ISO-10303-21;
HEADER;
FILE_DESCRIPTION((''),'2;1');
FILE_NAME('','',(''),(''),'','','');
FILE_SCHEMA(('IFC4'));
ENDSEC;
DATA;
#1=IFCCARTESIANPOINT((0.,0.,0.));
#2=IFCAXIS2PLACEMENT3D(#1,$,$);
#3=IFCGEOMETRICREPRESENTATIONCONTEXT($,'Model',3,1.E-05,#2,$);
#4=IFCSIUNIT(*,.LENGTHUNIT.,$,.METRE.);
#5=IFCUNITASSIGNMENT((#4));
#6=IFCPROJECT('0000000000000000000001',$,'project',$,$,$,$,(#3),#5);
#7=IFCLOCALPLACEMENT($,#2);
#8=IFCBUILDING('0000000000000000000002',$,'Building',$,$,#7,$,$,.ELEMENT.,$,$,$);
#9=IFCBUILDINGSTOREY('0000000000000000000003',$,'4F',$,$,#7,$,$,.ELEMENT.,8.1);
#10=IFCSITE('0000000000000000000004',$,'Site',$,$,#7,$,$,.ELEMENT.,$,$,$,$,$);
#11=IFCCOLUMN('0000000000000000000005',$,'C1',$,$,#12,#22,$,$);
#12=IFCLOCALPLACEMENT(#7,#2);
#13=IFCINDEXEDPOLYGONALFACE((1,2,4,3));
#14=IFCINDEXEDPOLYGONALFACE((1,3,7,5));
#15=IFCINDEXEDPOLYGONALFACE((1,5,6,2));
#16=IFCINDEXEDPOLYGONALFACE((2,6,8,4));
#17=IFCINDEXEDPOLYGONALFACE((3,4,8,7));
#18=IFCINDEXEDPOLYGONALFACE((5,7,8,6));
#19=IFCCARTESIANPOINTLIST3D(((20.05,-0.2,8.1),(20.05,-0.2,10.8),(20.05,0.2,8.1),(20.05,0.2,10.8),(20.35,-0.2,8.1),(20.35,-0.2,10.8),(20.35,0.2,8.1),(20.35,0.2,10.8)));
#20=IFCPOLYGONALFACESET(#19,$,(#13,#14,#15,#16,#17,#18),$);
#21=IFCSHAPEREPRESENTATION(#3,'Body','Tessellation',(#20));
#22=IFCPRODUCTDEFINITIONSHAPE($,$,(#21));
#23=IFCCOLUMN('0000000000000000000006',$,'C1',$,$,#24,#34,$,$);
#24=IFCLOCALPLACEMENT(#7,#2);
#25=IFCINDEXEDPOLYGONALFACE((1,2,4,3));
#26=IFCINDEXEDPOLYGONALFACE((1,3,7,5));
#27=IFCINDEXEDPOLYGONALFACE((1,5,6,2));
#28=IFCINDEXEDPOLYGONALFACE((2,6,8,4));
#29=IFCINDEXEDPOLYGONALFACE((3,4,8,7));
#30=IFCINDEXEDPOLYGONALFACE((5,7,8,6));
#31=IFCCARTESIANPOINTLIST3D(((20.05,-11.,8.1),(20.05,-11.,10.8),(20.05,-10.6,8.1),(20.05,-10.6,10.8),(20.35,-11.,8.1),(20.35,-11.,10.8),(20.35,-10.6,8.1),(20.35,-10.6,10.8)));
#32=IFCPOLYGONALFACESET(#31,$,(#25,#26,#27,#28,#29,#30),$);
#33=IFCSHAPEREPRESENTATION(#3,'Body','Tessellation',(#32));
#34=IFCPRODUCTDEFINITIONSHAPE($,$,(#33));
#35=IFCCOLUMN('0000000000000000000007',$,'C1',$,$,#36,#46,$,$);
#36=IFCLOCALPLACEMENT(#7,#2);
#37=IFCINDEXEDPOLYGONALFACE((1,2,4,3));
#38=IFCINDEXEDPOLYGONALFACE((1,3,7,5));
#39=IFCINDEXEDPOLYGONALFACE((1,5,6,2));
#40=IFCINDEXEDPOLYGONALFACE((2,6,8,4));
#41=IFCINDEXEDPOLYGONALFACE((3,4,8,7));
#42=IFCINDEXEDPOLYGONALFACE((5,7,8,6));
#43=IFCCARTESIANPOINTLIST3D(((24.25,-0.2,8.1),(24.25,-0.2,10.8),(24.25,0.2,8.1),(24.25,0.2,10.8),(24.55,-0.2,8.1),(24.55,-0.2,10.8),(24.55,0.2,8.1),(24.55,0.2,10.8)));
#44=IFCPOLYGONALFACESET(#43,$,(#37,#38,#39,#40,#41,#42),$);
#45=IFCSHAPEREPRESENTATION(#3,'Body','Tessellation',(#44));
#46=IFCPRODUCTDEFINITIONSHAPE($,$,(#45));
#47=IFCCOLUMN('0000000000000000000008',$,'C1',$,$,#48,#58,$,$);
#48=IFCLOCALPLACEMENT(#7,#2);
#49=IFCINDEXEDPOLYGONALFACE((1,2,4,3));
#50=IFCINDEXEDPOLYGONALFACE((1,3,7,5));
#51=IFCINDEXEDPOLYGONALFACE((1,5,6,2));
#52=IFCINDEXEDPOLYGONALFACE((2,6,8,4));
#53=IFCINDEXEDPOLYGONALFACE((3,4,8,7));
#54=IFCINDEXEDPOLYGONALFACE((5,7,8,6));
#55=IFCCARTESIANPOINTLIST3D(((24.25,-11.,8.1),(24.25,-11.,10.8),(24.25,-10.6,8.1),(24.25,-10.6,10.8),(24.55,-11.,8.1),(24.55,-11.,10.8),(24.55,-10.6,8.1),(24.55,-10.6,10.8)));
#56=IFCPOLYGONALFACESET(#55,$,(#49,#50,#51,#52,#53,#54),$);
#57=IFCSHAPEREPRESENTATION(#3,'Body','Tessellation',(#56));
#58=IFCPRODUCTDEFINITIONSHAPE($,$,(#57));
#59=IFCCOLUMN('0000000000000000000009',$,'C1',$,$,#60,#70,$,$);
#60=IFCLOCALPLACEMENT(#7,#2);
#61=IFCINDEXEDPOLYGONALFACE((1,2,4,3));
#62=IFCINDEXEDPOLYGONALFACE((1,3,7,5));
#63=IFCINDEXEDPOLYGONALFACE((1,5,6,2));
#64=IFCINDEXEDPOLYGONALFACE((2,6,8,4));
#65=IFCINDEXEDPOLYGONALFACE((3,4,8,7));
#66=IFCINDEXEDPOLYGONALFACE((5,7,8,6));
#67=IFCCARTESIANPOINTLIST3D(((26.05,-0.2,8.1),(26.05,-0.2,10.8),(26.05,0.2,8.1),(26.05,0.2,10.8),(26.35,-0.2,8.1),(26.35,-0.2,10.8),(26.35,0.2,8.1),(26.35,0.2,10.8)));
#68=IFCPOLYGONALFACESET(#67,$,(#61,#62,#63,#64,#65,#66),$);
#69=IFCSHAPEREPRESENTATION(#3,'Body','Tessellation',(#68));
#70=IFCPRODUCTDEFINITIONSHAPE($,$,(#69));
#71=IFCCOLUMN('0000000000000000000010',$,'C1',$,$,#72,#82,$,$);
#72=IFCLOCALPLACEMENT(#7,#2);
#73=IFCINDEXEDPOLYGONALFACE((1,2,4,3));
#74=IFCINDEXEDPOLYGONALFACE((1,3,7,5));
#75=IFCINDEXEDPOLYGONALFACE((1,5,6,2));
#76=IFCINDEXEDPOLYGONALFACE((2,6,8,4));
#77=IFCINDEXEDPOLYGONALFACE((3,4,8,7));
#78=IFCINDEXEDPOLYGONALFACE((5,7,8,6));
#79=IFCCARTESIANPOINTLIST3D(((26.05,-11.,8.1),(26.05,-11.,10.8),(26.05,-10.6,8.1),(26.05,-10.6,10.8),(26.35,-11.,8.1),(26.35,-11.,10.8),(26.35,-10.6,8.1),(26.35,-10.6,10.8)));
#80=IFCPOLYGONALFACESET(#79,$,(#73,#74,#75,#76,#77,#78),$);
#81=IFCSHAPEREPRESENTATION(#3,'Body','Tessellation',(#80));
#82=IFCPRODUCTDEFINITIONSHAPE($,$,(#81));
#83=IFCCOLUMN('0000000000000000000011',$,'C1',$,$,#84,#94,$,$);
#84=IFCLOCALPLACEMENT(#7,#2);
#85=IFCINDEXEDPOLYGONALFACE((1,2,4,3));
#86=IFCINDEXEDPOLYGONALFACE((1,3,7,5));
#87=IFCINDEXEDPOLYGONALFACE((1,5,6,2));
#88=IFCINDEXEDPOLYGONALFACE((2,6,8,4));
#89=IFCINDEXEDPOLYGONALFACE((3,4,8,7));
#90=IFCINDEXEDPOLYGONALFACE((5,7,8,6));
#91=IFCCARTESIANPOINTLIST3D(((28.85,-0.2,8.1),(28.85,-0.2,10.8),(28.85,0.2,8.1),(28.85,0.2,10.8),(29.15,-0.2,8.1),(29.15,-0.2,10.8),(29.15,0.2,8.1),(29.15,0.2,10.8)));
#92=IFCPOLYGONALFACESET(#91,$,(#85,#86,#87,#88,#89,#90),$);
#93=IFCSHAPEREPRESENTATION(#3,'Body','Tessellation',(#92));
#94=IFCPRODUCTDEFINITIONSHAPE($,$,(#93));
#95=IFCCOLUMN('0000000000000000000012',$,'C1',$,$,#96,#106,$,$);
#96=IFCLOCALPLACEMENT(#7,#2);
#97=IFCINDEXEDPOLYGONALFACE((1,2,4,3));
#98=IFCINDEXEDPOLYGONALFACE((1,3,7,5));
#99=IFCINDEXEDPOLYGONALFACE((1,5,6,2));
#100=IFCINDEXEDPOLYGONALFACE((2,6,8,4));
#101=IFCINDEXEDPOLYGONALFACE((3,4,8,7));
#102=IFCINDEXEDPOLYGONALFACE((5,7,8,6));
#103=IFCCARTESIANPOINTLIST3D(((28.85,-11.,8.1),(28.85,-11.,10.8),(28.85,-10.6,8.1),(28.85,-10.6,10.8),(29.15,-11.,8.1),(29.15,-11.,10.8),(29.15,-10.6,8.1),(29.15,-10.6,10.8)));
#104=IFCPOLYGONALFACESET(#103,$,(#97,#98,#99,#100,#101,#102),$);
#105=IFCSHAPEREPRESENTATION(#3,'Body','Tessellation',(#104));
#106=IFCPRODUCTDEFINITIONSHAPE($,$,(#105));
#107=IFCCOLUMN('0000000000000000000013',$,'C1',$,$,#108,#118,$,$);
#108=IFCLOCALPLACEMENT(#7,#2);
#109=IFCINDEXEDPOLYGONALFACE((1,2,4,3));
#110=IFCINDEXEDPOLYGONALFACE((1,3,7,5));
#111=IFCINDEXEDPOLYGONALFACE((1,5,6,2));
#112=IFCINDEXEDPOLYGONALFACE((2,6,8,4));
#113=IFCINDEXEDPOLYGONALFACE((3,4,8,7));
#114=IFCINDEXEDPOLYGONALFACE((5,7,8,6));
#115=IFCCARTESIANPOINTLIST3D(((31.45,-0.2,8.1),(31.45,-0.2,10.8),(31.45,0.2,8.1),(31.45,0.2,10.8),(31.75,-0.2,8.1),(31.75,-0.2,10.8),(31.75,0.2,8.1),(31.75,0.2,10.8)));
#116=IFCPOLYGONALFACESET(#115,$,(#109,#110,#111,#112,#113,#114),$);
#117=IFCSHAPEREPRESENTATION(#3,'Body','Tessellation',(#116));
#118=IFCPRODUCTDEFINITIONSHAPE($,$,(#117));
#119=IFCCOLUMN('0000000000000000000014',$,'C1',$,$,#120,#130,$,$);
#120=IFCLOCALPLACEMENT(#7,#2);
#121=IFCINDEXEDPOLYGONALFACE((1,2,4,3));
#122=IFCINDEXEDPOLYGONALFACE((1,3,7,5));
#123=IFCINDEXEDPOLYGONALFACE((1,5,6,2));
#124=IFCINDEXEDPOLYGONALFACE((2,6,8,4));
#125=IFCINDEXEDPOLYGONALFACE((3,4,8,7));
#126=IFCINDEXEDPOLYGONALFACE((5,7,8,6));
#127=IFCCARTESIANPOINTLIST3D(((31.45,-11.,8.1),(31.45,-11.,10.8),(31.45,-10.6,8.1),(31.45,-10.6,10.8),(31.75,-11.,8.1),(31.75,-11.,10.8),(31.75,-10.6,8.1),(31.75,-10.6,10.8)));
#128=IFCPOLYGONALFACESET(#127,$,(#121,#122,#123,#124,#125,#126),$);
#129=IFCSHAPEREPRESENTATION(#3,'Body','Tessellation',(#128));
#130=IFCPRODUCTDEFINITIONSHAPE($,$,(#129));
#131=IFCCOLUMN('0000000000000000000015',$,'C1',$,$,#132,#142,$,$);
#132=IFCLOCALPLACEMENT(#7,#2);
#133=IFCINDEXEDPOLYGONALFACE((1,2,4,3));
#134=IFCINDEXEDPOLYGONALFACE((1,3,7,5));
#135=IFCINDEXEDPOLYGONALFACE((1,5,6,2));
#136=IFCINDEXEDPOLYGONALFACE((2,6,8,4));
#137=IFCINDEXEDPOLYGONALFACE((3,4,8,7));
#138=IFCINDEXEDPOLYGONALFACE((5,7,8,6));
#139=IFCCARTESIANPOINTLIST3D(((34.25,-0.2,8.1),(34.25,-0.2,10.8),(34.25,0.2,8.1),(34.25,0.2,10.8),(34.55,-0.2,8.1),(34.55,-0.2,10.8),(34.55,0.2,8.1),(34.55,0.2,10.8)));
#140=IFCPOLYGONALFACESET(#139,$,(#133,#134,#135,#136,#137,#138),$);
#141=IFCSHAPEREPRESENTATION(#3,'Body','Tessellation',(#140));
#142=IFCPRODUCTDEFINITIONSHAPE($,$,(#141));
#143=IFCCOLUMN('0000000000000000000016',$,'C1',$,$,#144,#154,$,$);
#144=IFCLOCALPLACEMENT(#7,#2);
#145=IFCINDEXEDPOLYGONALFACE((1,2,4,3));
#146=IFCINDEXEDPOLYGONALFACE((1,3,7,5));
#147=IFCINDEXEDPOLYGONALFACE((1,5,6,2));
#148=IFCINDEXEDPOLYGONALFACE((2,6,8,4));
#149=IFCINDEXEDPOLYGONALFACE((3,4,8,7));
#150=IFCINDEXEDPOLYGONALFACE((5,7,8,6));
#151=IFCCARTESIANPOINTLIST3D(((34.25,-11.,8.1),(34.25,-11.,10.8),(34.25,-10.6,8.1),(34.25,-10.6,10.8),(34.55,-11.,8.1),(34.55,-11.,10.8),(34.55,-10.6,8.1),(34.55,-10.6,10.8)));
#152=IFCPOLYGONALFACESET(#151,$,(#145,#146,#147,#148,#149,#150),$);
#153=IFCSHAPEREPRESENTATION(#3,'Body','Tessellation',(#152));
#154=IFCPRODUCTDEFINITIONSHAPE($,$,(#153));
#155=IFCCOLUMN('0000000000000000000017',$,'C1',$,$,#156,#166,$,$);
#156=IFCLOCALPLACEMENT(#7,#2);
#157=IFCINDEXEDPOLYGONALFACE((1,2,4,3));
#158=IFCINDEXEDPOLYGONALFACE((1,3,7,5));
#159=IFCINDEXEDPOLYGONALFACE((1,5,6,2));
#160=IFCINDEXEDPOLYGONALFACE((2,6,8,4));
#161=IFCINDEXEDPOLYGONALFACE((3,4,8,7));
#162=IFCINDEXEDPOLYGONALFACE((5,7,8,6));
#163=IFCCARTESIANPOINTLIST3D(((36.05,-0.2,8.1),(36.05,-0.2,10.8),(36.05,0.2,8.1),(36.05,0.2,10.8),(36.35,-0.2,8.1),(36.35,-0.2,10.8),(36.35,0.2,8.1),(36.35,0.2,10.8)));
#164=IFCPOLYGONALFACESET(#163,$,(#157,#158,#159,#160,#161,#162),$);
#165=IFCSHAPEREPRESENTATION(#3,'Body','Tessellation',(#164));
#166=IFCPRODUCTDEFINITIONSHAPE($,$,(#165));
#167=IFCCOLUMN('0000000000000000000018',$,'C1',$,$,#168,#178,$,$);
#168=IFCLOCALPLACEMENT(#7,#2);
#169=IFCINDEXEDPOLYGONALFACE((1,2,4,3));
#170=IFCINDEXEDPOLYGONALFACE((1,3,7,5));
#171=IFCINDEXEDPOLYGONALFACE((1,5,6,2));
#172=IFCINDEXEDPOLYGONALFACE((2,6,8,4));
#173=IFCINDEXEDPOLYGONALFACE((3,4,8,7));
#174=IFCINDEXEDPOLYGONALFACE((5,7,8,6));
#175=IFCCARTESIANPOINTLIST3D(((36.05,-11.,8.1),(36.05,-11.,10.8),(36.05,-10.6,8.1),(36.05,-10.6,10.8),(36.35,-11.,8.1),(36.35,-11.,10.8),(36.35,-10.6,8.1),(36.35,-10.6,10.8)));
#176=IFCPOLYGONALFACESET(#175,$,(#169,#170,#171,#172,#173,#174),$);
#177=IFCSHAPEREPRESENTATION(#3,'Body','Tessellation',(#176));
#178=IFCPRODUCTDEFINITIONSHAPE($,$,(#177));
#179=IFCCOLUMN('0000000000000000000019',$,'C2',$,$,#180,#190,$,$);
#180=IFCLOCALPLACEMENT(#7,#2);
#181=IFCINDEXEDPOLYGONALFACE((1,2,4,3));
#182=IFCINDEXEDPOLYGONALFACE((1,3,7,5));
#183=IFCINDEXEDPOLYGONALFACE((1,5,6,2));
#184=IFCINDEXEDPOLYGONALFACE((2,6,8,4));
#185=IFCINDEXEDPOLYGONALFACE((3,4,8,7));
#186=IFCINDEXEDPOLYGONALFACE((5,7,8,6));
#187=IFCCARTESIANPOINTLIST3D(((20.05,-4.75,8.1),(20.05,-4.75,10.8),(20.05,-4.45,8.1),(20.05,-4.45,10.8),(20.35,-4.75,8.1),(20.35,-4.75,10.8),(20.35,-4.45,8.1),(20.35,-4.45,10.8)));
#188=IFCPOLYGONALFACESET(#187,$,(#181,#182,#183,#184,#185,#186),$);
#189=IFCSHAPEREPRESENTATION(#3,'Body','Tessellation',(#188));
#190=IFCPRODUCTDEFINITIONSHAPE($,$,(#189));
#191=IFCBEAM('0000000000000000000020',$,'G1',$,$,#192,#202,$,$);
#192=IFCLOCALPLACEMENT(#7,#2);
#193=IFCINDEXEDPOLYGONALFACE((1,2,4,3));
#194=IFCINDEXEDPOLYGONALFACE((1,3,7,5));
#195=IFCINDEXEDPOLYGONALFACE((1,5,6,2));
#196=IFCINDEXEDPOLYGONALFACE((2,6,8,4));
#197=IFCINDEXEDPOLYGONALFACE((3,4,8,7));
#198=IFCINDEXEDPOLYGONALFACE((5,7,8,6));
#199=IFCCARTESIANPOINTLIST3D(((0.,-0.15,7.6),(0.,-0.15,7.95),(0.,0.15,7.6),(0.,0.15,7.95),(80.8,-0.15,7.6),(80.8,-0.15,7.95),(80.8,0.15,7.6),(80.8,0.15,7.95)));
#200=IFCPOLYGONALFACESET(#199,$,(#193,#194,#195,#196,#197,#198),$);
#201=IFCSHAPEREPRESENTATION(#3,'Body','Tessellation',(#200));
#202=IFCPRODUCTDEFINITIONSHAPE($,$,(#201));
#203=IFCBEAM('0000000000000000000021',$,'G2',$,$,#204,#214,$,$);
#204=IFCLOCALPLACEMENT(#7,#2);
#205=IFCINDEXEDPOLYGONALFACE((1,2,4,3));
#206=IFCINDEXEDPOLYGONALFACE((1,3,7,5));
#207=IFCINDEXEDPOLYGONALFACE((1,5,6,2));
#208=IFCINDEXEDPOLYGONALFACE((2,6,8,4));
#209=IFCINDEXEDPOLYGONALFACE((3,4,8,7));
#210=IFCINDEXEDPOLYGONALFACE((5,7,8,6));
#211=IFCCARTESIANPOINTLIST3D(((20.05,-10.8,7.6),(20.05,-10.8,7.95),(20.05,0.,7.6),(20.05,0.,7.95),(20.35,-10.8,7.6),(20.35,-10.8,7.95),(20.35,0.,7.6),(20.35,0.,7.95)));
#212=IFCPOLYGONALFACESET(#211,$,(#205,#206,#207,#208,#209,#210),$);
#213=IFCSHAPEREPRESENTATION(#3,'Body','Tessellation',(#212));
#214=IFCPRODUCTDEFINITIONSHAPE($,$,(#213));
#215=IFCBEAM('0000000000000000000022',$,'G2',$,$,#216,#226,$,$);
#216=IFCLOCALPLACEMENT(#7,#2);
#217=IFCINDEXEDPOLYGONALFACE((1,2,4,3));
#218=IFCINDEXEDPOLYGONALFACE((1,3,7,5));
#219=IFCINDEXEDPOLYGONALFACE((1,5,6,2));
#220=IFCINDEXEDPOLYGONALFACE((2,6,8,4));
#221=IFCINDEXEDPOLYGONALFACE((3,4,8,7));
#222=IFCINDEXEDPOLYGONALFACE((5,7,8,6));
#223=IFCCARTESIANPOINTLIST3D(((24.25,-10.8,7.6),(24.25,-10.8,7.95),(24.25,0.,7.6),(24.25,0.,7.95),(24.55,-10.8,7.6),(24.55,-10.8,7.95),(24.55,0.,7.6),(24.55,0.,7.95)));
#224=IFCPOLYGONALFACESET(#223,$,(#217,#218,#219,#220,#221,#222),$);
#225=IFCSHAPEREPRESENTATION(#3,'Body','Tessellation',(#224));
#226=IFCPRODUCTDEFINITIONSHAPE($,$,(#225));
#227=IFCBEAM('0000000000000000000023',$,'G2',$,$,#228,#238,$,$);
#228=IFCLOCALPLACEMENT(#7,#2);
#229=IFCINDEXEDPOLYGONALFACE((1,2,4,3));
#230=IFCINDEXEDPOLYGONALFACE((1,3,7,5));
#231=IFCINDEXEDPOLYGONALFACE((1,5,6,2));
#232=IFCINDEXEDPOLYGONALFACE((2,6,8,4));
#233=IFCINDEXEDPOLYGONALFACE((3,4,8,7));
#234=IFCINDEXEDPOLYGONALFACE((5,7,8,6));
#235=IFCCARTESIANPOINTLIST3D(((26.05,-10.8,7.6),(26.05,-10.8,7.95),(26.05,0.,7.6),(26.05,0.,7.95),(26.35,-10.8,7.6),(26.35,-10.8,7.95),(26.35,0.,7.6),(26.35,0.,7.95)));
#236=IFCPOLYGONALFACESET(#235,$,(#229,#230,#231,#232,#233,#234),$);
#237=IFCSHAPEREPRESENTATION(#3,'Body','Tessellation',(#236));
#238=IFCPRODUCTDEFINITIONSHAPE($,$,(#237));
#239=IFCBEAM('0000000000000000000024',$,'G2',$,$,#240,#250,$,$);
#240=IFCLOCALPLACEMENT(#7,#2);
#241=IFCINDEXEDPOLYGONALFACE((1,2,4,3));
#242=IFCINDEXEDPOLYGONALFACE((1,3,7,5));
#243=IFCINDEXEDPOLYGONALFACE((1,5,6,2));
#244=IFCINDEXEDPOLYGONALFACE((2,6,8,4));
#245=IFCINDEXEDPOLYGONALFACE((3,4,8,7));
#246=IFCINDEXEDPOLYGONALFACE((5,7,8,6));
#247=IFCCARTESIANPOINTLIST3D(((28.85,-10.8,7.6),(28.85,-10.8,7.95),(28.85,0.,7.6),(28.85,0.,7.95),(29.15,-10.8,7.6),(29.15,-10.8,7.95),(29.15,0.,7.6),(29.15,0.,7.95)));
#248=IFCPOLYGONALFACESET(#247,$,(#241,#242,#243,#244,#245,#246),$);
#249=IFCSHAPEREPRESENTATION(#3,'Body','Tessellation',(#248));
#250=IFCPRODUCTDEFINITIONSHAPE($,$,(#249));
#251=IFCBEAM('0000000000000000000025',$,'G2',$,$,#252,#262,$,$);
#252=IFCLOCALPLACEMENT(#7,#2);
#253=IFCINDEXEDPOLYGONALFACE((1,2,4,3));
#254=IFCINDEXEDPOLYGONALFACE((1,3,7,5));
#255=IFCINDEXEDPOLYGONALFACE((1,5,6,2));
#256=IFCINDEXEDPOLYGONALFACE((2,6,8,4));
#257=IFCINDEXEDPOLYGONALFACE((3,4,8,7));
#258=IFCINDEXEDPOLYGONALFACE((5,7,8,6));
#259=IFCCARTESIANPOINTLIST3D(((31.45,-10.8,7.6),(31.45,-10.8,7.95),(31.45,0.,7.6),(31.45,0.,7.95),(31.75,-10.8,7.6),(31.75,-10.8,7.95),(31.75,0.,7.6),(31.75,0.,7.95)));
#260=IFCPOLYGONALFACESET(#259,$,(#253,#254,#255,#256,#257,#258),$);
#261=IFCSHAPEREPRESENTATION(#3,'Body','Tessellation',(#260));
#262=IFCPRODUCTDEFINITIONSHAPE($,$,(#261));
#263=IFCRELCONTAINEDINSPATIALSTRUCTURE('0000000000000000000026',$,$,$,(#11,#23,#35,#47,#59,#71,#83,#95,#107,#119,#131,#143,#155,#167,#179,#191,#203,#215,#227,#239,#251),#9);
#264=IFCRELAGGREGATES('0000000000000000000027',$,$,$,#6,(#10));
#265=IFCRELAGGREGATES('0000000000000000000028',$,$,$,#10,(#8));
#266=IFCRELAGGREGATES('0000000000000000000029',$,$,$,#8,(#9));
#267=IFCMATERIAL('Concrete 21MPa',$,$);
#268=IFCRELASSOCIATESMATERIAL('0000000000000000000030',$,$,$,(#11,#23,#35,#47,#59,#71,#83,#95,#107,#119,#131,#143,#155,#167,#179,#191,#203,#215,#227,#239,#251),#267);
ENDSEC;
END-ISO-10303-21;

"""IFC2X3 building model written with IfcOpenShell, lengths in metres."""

from ifc_helpers import new_model, si_unit, frame, origin, origin_2d, place, context, project, spatial, rectangle, extrude, material, element, save


model = new_model("IFC2X3")

# Units and contexts
model_context = context("Model", 3, precision=1e-05, world=origin())
ifc_project = project(units=[si_unit("LENGTHUNIT", "METRE")], contexts=[model_context])

# Site, building, storey
placement = place(None, origin())
site = spatial("IfcSite", under=ifc_project, at=placement, Name="Site", CompositionType="ELEMENT")
building = spatial("IfcBuilding", under=site, at=placement, Name="Building", CompositionType="ELEMENT")
storey = spatial("IfcBuildingStorey", under=building, at=placement, Name="4F", CompositionType="ELEMENT", Elevation=8.1)

# Columns
ifc_material_1 = material(Name="Concrete 21MPa")
for number, where, name in (
    (1, (20.2, 0.0, 8.1), "C1"),
    (2, (20.2, -10.8, 8.1), "C1"),
    (3, (24.4, 0.0, 8.1), "C1"),
    (4, (24.4, -10.8, 8.1), "C1"),
    (5, (26.2, 0.0, 8.1), "C1"),
    (6, (26.2, -10.8, 8.1), "C1"),
    (7, (29.0, 0.0, 8.1), "C1"),
    (8, (29.0, -10.8, 8.1), "C1"),
    (9, (31.6, 0.0, 8.1), "C1"),
    (10, (31.6, -10.8, 8.1), "C1"),
    (11, (34.4, 0.0, 8.1), "C1"),
    (12, (34.4, -10.8, 8.1), "C1"),
    (13, (36.2, 0.0, 8.1), "C1"),
    (14, (36.2, -10.8, 8.1), "C1"),
):
    element("IfcColumn", number, at=place(None, frame(where)), inside=storey, material=ifc_material_1, Name=name, context=model_context, shape_type="SweptSolid", body=[
        extrude(rectangle(XDim=0.3, YDim=0.4, at=origin_2d()), origin(), (0.0, 0.0, 1.0), 2.7),
    ])
column_placement = place(None, frame((20.2, -4.6, 8.1)))
element("IfcColumn", 15, at=column_placement, inside=storey, material=ifc_material_1, Name="C2", context=model_context, shape_type="SweptSolid", body=[
    extrude(rectangle(XDim=0.3, YDim=0.3, at=origin_2d()), origin(), (0.0, 0.0, 1.0), 2.7),
])

# Beams
beam_placement = place(None, frame((40.4, 0.0, 7.6)))
element("IfcBeam", 16, at=beam_placement, inside=storey, material=ifc_material_1, Name="G1", context=model_context, shape_type="SweptSolid", body=[
    extrude(rectangle(XDim=80.8, YDim=0.3, at=origin_2d()), origin(), (0.0, 0.0, 1.0), 0.35),
])
for number, where, name in (
    (17, (20.2, -5.4, 7.6), "G2"),
    (18, (24.4, -5.4, 7.6), "G2"),
    (19, (26.2, -5.4, 7.6), "G2"),
    (20, (29.0, -5.4, 7.6), "G2"),
    (21, (31.6, -5.4, 7.6), "G2"),
):
    element("IfcBeam", number, at=place(None, frame(where)), inside=storey, material=ifc_material_1, Name=name, context=model_context, shape_type="SweptSolid", body=[
        extrude(rectangle(XDim=0.3, YDim=10.8, at=origin_2d()), origin(), (0.0, 0.0, 1.0), 0.35),
    ])

save(model, "model.ifc")
